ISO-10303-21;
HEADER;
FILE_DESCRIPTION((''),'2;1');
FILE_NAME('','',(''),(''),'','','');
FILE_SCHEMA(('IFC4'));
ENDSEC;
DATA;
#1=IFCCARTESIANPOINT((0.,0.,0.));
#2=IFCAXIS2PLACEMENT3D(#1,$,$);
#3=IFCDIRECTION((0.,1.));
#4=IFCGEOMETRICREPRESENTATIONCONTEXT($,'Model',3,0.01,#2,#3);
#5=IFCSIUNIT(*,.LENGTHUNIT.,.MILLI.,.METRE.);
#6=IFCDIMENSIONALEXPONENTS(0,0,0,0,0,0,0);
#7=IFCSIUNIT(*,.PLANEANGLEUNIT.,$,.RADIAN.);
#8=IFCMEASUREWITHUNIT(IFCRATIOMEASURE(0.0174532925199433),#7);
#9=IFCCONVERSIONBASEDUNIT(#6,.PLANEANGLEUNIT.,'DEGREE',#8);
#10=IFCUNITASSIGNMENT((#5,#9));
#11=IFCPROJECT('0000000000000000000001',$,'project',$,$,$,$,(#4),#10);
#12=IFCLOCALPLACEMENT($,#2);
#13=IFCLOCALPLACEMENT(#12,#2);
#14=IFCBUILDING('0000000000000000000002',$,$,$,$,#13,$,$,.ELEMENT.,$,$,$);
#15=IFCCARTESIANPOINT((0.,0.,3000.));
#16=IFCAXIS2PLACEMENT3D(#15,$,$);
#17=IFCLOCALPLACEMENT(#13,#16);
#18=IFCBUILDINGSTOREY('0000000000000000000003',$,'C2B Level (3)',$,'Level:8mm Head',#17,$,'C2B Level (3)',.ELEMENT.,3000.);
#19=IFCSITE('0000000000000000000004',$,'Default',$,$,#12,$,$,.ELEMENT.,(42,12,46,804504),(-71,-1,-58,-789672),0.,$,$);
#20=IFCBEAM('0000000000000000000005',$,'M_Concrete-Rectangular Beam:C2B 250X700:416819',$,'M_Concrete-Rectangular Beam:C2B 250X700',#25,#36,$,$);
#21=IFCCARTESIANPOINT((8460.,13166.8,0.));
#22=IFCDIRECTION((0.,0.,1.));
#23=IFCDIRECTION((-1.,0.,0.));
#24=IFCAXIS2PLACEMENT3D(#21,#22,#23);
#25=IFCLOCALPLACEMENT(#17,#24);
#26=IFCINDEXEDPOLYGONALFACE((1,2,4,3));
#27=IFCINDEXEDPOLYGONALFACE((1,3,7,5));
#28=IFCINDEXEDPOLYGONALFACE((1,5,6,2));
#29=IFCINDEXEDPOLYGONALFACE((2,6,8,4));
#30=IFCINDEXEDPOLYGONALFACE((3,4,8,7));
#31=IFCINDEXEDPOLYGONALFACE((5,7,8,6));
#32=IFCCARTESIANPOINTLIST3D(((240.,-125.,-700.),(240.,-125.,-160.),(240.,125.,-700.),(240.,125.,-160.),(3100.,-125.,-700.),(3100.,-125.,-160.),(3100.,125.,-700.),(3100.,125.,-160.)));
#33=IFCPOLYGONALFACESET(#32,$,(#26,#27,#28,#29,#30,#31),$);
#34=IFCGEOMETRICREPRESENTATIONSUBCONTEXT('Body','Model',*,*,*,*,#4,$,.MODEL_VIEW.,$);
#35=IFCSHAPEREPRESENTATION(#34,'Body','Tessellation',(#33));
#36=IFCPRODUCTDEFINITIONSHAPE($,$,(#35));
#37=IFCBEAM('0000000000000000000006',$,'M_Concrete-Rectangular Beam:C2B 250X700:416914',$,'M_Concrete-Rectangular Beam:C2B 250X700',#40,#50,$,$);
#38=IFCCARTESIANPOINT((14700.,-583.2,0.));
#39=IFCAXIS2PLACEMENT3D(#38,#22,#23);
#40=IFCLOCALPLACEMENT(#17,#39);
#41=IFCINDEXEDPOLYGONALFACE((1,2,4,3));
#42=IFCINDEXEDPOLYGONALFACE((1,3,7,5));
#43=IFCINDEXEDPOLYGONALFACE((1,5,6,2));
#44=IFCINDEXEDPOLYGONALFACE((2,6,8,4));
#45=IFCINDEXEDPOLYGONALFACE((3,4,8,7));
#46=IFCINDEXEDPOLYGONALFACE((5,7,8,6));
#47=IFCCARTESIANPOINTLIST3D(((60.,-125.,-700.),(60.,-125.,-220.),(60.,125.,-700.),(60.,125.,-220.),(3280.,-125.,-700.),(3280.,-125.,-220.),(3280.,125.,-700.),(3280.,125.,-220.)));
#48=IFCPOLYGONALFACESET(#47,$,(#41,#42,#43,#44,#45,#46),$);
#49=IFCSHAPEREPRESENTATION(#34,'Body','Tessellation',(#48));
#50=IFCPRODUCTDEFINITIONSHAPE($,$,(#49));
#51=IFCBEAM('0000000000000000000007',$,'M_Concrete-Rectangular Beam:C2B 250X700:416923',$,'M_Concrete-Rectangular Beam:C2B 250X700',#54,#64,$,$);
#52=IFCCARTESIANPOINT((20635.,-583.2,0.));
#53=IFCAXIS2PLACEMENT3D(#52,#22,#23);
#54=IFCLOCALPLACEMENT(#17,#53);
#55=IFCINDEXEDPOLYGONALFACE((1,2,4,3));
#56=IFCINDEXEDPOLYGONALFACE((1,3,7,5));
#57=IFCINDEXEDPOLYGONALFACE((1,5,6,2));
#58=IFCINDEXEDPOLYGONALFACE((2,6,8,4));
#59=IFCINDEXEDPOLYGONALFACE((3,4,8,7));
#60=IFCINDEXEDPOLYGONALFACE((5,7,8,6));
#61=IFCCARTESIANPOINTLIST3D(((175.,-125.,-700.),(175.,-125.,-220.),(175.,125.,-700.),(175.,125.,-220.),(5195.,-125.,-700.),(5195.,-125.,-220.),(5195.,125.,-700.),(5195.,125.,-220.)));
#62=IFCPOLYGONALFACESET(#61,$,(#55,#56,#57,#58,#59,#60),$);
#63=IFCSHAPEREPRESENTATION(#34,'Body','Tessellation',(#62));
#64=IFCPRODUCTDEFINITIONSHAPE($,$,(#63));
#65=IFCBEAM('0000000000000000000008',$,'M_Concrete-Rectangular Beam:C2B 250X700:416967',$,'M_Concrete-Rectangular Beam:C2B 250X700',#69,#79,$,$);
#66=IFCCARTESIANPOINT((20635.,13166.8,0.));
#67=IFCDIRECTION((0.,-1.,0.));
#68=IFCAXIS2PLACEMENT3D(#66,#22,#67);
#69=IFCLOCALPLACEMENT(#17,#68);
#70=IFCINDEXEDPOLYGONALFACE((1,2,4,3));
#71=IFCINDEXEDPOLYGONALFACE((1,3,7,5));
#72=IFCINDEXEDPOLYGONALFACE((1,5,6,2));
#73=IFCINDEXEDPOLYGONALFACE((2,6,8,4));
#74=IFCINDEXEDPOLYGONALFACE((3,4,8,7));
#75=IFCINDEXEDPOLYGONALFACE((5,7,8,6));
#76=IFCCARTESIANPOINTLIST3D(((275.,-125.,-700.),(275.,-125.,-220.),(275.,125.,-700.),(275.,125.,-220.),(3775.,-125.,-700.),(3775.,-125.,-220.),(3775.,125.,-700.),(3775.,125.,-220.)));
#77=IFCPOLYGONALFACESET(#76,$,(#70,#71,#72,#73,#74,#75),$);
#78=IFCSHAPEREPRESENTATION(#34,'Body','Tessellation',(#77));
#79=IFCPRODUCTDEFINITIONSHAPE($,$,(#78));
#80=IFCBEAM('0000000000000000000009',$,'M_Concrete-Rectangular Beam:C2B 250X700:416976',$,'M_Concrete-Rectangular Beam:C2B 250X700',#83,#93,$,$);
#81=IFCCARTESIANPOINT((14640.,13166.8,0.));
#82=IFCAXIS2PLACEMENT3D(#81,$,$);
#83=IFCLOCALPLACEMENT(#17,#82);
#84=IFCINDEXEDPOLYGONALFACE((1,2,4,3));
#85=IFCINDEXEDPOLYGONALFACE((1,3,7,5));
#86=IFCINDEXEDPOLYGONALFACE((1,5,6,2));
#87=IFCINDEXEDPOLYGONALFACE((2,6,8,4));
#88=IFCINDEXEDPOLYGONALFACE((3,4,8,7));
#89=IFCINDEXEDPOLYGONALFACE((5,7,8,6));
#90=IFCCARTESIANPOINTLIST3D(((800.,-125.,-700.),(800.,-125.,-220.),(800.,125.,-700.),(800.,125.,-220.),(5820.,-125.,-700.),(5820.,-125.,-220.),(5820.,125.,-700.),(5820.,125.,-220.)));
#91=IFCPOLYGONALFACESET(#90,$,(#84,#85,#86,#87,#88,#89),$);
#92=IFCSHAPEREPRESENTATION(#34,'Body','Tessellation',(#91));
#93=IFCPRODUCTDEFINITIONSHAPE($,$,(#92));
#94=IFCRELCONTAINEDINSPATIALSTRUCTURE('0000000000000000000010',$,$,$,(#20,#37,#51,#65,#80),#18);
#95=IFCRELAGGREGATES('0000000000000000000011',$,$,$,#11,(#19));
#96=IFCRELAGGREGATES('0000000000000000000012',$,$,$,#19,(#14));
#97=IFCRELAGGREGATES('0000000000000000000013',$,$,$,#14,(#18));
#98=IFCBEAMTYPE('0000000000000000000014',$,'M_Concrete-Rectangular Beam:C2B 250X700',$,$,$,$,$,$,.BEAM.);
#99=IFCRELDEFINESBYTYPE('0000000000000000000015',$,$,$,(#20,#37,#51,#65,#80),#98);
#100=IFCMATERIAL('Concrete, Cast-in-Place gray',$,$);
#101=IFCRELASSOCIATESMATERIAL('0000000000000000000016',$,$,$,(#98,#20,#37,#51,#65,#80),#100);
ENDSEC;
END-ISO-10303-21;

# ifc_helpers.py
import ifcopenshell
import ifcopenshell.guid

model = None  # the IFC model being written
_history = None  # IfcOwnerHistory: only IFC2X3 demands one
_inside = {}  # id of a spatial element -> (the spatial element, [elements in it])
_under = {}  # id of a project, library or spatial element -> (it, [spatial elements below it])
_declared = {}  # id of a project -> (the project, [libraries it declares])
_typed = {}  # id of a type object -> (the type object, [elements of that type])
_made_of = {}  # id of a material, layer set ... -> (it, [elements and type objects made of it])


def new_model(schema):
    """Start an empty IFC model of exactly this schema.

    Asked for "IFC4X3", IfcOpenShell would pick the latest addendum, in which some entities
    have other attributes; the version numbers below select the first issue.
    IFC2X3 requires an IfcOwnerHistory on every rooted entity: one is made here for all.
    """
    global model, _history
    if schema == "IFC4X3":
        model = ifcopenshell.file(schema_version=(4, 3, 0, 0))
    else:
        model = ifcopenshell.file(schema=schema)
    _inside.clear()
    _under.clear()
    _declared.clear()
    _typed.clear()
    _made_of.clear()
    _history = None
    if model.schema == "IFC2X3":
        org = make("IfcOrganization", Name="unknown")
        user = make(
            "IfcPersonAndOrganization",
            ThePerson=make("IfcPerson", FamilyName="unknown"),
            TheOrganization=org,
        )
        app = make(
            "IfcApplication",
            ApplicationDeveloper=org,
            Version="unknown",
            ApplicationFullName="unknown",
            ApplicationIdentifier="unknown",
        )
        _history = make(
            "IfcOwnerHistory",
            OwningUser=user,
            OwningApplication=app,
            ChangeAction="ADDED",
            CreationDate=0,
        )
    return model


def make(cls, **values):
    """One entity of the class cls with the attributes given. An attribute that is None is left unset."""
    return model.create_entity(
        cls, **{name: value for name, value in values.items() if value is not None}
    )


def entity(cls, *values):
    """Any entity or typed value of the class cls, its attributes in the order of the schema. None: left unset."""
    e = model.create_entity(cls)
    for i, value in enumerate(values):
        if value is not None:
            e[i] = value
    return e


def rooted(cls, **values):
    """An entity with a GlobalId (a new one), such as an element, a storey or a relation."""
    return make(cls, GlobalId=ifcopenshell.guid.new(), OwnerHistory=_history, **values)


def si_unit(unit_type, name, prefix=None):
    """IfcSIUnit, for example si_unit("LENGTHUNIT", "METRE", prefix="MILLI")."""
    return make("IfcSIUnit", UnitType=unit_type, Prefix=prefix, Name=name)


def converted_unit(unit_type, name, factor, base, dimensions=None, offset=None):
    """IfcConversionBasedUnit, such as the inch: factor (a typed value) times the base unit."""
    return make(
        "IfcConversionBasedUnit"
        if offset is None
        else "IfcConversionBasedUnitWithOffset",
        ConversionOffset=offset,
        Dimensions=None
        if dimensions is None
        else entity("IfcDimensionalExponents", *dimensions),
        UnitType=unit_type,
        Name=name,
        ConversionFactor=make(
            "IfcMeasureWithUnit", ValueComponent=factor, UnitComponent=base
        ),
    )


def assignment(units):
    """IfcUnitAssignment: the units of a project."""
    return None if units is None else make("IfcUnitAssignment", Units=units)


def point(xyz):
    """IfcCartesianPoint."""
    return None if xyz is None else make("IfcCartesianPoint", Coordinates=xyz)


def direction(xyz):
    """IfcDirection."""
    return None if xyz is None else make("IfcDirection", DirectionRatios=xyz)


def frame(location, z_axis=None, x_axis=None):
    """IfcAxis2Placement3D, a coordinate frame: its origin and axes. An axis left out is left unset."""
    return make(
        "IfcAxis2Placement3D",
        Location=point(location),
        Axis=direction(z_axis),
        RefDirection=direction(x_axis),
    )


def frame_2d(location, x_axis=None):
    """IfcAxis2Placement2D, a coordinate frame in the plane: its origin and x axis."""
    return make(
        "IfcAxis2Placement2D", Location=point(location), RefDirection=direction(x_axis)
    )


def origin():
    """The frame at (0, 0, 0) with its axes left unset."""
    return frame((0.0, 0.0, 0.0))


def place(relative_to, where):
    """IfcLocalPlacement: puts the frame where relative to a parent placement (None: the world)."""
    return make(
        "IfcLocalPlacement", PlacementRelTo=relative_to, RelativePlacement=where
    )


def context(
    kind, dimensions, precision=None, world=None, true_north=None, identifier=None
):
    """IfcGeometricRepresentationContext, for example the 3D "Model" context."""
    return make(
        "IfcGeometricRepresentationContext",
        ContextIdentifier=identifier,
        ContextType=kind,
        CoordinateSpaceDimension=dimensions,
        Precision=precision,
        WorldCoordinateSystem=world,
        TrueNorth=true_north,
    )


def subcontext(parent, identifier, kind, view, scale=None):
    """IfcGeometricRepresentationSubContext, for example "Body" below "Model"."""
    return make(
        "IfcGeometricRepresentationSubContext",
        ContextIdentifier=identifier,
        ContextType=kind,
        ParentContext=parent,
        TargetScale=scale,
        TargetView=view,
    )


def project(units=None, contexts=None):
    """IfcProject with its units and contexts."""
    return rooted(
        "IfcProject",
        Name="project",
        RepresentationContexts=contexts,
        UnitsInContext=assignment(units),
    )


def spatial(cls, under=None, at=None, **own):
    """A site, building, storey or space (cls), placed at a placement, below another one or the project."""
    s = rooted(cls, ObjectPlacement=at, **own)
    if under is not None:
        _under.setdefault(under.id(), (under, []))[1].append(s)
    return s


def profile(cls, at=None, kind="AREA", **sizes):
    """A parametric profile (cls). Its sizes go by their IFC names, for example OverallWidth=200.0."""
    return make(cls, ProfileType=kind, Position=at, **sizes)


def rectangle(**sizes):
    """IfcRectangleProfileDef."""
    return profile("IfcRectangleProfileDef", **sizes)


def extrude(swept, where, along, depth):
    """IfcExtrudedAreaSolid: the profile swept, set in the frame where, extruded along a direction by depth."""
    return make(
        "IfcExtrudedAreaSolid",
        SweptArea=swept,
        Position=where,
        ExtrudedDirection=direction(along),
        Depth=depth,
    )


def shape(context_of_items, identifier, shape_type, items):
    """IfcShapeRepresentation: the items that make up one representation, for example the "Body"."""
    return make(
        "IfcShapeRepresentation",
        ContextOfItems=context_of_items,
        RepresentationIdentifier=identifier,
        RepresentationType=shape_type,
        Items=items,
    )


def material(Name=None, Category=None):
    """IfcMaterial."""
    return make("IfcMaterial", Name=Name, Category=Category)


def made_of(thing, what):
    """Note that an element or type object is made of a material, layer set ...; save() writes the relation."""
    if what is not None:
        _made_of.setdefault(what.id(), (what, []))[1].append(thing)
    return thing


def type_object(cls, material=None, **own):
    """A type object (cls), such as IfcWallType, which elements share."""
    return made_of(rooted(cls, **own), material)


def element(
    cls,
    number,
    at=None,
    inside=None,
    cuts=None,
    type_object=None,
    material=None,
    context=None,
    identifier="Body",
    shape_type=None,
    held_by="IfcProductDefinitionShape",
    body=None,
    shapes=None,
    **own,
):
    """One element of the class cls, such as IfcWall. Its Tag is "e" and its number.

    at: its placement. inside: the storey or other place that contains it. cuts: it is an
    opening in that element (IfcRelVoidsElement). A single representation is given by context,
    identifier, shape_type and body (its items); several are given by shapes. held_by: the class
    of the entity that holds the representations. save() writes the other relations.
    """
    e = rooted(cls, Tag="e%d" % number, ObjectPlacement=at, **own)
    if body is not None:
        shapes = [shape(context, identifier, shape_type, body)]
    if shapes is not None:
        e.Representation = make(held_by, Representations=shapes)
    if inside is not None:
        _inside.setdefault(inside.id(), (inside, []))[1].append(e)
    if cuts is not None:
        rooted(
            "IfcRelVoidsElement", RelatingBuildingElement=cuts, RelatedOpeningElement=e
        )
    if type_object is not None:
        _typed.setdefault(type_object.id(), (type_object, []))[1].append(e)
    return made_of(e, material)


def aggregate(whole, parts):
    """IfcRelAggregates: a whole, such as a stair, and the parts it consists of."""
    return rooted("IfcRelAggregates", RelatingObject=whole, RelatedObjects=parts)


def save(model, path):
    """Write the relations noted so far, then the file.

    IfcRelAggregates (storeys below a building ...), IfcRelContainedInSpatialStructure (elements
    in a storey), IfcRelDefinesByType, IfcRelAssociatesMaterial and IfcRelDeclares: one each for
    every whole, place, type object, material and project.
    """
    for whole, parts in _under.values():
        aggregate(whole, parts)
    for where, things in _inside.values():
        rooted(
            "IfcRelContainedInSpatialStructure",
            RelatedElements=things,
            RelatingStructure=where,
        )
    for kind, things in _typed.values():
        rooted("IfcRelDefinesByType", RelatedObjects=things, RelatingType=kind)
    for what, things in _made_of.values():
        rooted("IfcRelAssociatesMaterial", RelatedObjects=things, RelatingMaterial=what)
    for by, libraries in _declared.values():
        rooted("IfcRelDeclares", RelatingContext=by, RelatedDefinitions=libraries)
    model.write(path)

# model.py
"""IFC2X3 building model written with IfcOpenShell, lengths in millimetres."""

from ifc_helpers import new_model, entity, si_unit, converted_unit, direction, frame, frame_2d, origin, place, context, subcontext, project, spatial, rectangle, extrude, material, type_object, element, save


model = new_model("IFC2X3")

# Units and contexts
model_context = context("Model", 3, precision=0.01, world=origin(), true_north=direction((0.0, 1.0)))
body_context = subcontext(model_context, "Body", "Model", "MODEL_VIEW")
ifc_project = project(units=[si_unit("LENGTHUNIT", "METRE", prefix="MILLI"), converted_unit("PLANEANGLEUNIT", "DEGREE", entity("IfcRatioMeasure", 0.0174532925199433), si_unit("PLANEANGLEUNIT", "RADIAN"), dimensions=[0, 0, 0, 0, 0, 0, 0])], contexts=[model_context])

# Site, building, storey
site_placement = place(None, origin())
site = spatial("IfcSite", under=ifc_project, at=site_placement, Name="Default", CompositionType="ELEMENT", RefLatitude=(42, 12, 46, 804504), RefLongitude=(-71, -1, -58, -789672), RefElevation=0.0)
building_placement = place(site_placement, origin())
building = spatial("IfcBuilding", under=site, at=building_placement, CompositionType="ELEMENT")
storey_placement = place(building_placement, frame((0.0, 0.0, 3000.0)))
storey = spatial("IfcBuildingStorey", under=building, at=storey_placement, Name="C2B Level (3)", ObjectType="Level:8mm Head", LongName="C2B Level (3)", CompositionType="ELEMENT", Elevation=3000.0)

# Beams
ifc_material_1 = material(Name="Concrete, Cast-in-Place gray")
beam_type_1 = type_object("IfcBeamType", Name="M_Concrete-Rectangular Beam:C2B 250X700", PredefinedType="BEAM", material=ifc_material_1)
beam_1_placement = place(storey_placement, frame((8460.0, 13166.8, 0.0), z_axis=(0.0, 0.0, 1.0), x_axis=(-1.0, 0.0, 0.0)))
element("IfcBeam", 1, at=beam_1_placement, inside=storey, type_object=beam_type_1, material=ifc_material_1, Name="M_Concrete-Rectangular Beam:C2B 250X700:416819", ObjectType="M_Concrete-Rectangular Beam:C2B 250X700", context=body_context, shape_type="SweptSolid", body=[
    extrude(rectangle(XDim=540.0, YDim=250.0, at=frame_2d((0.0, 0.0), x_axis=(1.0, 0.0))), frame((240.0, 0.0, -430.0), z_axis=(1.0, 0.0, 0.0), x_axis=(0.0, 0.0, -1.0)), (0.0, 0.0, 1.0), 2860.0),
])
beam_2_placement = place(storey_placement, frame((14700.0, -583.2, 0.0), z_axis=(0.0, 0.0, 1.0), x_axis=(-1.0, 0.0, 0.0)))
element("IfcBeam", 2, at=beam_2_placement, inside=storey, type_object=beam_type_1, material=ifc_material_1, Name="M_Concrete-Rectangular Beam:C2B 250X700:416914", ObjectType="M_Concrete-Rectangular Beam:C2B 250X700", context=body_context, shape_type="SweptSolid", body=[
    extrude(rectangle(XDim=480.0, YDim=250.0, at=frame_2d((0.0, 0.0), x_axis=(1.0, 0.0))), frame((60.0, 0.0, -460.0), z_axis=(1.0, 0.0, 0.0), x_axis=(0.0, 0.0, -1.0)), (0.0, 0.0, 1.0), 3220.0),
])
beam_3_placement = place(storey_placement, frame((20635.0, -583.2, 0.0), z_axis=(0.0, 0.0, 1.0), x_axis=(-1.0, 0.0, 0.0)))
element("IfcBeam", 3, at=beam_3_placement, inside=storey, type_object=beam_type_1, material=ifc_material_1, Name="M_Concrete-Rectangular Beam:C2B 250X700:416923", ObjectType="M_Concrete-Rectangular Beam:C2B 250X700", context=body_context, shape_type="SweptSolid", body=[
    extrude(rectangle(XDim=480.0, YDim=250.0, at=frame_2d((0.0, 0.0), x_axis=(1.0, 0.0))), frame((175.0, 0.0, -460.0), z_axis=(1.0, 0.0, 0.0), x_axis=(0.0, 0.0, -1.0)), (0.0, 0.0, 1.0), 5020.0),
])
beam_4_placement = place(storey_placement, frame((20635.0, 13166.8, 0.0), z_axis=(0.0, 0.0, 1.0), x_axis=(0.0, -1.0, 0.0)))
element("IfcBeam", 4, at=beam_4_placement, inside=storey, type_object=beam_type_1, material=ifc_material_1, Name="M_Concrete-Rectangular Beam:C2B 250X700:416967", ObjectType="M_Concrete-Rectangular Beam:C2B 250X700", context=body_context, shape_type="SweptSolid", body=[
    extrude(rectangle(XDim=480.0, YDim=250.0, at=frame_2d((0.0, 0.0), x_axis=(1.0, 0.0))), frame((275.0, 0.0, -460.0), z_axis=(1.0, 0.0, 0.0), x_axis=(0.0, 0.0, -1.0)), (0.0, 0.0, 1.0), 3500.0),
])
beam_5_placement = place(storey_placement, frame((14640.0, 13166.8, 0.0)))
element("IfcBeam", 5, at=beam_5_placement, inside=storey, type_object=beam_type_1, material=ifc_material_1, Name="M_Concrete-Rectangular Beam:C2B 250X700:416976", ObjectType="M_Concrete-Rectangular Beam:C2B 250X700", context=body_context, shape_type="SweptSolid", body=[
    extrude(rectangle(XDim=480.0, YDim=250.0, at=frame_2d((0.0, 0.0), x_axis=(1.0, 0.0))), frame((800.0, 0.0, -460.0), z_axis=(1.0, 0.0, 0.0), x_axis=(0.0, 0.0, -1.0)), (0.0, 0.0, 1.0), 5020.0),
])

save(model, "model.ifc")
